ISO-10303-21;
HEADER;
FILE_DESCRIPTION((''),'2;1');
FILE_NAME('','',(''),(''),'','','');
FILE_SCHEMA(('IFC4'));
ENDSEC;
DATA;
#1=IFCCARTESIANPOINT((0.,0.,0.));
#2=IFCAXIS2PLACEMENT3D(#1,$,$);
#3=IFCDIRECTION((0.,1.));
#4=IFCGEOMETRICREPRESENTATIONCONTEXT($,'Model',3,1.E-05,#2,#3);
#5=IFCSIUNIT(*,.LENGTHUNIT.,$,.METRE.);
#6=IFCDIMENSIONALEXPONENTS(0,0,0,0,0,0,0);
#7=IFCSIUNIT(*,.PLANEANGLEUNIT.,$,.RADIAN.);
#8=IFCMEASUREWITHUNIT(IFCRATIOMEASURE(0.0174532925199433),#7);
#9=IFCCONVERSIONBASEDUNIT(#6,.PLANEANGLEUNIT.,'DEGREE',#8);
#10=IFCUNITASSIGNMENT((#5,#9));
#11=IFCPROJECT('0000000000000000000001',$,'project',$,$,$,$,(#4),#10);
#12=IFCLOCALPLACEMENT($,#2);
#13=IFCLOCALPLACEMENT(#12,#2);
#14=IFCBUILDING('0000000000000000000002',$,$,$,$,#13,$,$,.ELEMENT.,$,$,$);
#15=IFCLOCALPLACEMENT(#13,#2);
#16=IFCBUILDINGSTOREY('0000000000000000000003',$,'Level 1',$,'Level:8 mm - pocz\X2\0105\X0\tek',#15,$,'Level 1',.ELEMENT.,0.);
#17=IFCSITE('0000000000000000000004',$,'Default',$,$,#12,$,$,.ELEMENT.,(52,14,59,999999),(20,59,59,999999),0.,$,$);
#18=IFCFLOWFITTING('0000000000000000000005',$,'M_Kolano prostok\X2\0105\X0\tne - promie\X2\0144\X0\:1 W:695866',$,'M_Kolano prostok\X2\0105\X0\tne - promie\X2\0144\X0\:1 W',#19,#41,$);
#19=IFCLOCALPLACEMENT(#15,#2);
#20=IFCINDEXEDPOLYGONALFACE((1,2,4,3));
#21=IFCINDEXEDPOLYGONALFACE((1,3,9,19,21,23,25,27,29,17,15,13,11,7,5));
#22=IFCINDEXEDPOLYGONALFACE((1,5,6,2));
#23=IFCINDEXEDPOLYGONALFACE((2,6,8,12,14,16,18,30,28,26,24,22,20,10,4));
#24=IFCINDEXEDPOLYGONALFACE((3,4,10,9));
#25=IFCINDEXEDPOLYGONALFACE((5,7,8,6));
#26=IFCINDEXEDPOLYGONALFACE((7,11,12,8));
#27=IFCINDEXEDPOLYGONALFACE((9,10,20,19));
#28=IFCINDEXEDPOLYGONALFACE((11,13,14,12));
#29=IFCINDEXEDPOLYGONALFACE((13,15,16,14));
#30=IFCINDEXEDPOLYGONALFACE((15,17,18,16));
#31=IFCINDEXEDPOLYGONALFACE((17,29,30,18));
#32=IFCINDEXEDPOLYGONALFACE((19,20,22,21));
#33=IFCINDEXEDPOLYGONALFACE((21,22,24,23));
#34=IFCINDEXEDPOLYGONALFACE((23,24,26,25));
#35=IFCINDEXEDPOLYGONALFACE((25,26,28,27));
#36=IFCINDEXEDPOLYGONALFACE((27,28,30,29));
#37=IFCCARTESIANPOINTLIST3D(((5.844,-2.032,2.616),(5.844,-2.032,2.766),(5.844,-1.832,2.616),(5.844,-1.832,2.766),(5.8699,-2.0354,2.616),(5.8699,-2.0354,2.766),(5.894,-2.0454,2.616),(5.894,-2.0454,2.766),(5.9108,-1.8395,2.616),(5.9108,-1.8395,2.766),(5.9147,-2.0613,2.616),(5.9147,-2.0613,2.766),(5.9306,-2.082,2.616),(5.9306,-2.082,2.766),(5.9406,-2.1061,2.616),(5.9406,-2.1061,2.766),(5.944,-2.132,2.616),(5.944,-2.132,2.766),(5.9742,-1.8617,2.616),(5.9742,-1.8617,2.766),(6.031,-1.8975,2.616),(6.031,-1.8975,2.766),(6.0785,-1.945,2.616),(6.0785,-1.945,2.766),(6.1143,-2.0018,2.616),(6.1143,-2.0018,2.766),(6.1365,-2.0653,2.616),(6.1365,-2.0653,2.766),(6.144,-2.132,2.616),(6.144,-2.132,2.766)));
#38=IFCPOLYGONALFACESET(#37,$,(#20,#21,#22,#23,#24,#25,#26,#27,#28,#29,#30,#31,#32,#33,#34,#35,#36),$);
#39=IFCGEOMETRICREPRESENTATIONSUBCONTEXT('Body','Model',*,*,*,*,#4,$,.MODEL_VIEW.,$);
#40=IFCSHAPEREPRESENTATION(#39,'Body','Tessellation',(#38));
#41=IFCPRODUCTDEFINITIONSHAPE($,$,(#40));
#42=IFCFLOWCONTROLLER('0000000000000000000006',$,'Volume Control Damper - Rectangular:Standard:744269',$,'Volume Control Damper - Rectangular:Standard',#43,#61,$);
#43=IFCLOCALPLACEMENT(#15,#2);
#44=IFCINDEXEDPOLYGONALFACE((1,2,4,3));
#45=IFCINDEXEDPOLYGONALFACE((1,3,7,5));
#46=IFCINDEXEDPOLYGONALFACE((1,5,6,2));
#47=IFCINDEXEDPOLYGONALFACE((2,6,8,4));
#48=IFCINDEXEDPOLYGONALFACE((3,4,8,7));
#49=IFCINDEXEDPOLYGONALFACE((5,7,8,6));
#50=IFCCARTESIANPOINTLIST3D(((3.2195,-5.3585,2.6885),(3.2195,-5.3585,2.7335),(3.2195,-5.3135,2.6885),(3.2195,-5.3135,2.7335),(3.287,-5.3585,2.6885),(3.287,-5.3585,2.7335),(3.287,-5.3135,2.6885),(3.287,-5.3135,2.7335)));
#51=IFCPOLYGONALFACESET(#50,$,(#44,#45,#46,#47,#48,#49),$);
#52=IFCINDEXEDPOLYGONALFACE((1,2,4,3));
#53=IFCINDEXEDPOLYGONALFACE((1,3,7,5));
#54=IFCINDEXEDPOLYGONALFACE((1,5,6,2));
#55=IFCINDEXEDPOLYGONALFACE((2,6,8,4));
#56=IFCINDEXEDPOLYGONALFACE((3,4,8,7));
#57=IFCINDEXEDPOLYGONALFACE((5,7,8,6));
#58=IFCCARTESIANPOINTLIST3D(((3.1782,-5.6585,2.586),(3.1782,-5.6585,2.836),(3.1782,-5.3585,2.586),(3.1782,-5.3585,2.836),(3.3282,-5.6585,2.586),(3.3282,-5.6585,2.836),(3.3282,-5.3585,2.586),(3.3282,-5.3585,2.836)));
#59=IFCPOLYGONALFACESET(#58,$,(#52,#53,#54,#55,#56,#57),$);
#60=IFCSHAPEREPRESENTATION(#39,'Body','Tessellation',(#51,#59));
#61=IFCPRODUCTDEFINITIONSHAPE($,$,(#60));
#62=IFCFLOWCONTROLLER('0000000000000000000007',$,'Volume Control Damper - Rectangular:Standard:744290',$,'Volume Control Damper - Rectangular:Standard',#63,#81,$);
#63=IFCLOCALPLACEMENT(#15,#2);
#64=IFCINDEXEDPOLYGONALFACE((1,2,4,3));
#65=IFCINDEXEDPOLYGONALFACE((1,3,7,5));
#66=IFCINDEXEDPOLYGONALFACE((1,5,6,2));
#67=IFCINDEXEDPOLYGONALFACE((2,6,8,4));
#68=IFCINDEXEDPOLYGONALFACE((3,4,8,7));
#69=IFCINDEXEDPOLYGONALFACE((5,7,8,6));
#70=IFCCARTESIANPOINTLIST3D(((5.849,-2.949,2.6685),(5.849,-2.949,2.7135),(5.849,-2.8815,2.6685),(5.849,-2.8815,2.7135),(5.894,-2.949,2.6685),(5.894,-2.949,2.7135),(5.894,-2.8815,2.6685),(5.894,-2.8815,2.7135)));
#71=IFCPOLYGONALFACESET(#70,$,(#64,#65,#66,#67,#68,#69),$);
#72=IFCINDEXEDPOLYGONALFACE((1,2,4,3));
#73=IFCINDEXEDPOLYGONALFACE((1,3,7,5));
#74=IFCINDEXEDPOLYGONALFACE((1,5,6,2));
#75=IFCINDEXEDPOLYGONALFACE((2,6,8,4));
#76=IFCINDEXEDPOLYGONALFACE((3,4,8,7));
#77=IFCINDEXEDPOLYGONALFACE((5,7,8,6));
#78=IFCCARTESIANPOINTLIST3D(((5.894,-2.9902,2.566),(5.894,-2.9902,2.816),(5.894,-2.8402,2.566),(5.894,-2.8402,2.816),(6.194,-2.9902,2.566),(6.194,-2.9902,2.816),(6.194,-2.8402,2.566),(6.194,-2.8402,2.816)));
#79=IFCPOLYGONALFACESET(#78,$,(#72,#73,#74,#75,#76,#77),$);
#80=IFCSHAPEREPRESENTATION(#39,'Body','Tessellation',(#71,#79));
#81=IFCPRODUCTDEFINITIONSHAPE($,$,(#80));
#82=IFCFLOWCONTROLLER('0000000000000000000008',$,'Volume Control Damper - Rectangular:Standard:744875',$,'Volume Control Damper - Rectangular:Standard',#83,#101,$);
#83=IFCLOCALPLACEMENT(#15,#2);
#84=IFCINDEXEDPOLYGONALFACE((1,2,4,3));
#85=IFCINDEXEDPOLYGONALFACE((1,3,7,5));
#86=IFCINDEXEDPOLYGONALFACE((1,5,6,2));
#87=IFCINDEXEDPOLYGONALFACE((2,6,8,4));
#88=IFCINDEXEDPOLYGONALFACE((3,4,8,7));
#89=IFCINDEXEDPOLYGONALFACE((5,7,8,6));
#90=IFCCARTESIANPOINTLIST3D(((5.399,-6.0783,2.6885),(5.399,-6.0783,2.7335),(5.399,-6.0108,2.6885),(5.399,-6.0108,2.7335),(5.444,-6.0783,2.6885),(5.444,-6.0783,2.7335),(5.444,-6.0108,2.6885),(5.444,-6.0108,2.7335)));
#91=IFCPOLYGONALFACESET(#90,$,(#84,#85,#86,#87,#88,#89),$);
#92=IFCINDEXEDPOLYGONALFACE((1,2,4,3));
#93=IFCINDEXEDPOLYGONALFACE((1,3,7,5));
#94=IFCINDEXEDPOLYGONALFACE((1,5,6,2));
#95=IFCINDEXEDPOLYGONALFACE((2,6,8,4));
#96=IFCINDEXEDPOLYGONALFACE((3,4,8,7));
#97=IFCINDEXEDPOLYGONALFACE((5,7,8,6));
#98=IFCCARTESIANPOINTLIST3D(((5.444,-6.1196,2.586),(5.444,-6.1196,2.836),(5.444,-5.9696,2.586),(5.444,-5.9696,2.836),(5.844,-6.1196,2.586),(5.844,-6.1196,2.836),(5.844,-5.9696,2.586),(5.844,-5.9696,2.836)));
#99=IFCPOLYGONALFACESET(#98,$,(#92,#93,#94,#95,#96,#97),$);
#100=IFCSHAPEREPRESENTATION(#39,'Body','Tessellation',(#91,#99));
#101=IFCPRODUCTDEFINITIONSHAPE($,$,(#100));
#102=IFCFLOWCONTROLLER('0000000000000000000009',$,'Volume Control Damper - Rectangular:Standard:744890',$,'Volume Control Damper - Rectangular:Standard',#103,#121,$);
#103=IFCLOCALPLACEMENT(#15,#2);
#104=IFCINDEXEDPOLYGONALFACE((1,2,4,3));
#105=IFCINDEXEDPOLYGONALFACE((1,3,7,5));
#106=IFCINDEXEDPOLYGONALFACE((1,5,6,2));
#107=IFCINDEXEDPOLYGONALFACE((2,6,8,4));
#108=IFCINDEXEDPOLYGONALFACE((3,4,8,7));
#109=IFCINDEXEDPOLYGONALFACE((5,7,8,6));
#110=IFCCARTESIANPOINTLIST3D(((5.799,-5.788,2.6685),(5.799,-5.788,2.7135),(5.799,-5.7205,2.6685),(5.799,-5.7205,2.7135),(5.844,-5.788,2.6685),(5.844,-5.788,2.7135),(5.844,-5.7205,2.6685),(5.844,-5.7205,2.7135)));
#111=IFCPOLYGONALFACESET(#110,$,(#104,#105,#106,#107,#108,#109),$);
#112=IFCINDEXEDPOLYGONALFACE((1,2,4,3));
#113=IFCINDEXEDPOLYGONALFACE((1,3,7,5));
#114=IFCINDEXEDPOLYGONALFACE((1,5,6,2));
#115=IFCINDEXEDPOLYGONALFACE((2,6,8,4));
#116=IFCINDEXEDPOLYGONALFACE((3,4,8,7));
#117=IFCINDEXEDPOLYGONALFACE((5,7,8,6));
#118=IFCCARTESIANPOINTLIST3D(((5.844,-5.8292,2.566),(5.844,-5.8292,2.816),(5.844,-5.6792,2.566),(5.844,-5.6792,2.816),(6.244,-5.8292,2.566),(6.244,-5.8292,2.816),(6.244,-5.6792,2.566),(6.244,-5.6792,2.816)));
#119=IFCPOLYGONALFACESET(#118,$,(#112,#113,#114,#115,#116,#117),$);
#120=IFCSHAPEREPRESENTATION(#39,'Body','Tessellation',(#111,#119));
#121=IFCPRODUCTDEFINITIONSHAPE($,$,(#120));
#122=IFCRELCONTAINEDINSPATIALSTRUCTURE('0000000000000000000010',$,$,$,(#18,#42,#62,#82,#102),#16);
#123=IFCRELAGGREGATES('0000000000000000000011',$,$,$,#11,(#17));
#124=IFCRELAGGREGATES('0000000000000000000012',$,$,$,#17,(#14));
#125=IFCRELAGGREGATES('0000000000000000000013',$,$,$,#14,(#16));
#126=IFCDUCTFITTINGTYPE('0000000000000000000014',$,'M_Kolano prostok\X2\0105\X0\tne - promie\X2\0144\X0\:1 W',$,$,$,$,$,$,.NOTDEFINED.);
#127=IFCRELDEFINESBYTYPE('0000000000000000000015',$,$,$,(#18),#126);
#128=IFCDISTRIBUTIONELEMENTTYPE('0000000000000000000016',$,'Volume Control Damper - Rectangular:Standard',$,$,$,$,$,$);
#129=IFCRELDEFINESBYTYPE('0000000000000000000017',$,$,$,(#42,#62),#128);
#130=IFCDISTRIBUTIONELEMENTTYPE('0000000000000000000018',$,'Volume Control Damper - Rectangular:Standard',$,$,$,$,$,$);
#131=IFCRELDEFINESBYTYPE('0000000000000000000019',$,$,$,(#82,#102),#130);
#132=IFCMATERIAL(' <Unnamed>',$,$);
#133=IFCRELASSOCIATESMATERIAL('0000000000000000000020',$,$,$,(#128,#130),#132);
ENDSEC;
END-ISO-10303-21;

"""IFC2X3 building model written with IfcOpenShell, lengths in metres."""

from ifc_helpers import new_model, entity, si_unit, converted_unit, direction, frame, frame_2d, origin, origin_2d_with_axis, place, context, subcontext, project, spatial, polyline, circle_curve, parameter, trimmed, segment, composite_curve, rectangle, outline, extrude, source, transform, mapped, material, type_object, type_shapes, element, save


model = new_model("IFC2X3")

# Units and contexts
model_context = context("Model", 3, precision=1e-05, world=origin(), true_north=direction((0.0, 1.0)))
body_context = subcontext(model_context, "Body", "Model", "MODEL_VIEW")
ifc_project = project(units=[si_unit("LENGTHUNIT", "METRE"), converted_unit("PLANEANGLEUNIT", "DEGREE", entity("IfcRatioMeasure", 0.0174532925199433), si_unit("PLANEANGLEUNIT", "RADIAN"), dimensions=[0, 0, 0, 0, 0, 0, 0])], contexts=[model_context])

# Site, building, storey
site_placement = place(None, origin())
site = spatial("IfcSite", under=ifc_project, at=site_placement, Name="Default", CompositionType="ELEMENT", RefLatitude=(52, 14, 59, 999999), RefLongitude=(20, 59, 59, 999999), RefElevation=0.0)
building_placement = place(site_placement, origin())
building = spatial("IfcBuilding", under=site, at=building_placement, CompositionType="ELEMENT")
storey_placement = place(building_placement, origin())
storey = spatial("IfcBuildingStorey", under=building, at=storey_placement, Name="Level 1", ObjectType="Level:8 mm - początek", LongName="Level 1", CompositionType="ELEMENT", Elevation=0.0)

# Flow fitting
duct_fitting_type_1 = type_object("IfcDuctFittingType", Name="M_Kolano prostokątne - promień:1 W", PredefinedType="NOTDEFINED")
shared_shape_1 = source(origin(), body_context, "Body", "SweptSolid", [
    extrude(outline(composite_curve([segment(polyline([(-0.2, -0.1), (0.0, -0.1)]), True, "CONTINUOUS"), segment(trimmed(circle_curve(frame_2d((0.1, -0.1), x_axis=(0.0, 1.0)), 0.1), [parameter(0.0)], [parameter(90.0)], True, "PARAMETER"), False, "CONTINUOUS"), segment(polyline([(0.1, 0.0), (0.1, 0.2)]), True, "CONTINUOUS"), segment(trimmed(circle_curve(frame_2d((0.1, -0.1), x_axis=(0.0, 1.0)), 0.3), [parameter(0.0)], [parameter(90.0)], True, "PARAMETER"), True, "CONTINUOUS")], self_intersect=False)), frame((-0.1, 0.1, -0.075), z_axis=(0.0, 0.0, 1.0), x_axis=(-1.0, 0.0, 0.0)), (0.0, 0.0, 1.0), 0.15),
])
type_shapes(duct_fitting_type_1, [shared_shape_1])
flow_fitting_1_placement = place(storey_placement, frame((6.044, -1.932, 2.691), z_axis=(0.0, 0.0, 1.0), x_axis=(0.0, 1.0, 0.0)))
element("IfcFlowFitting", 1, at=flow_fitting_1_placement, inside=storey, type_object=duct_fitting_type_1, Name="M_Kolano prostokątne - promień:1 W:695866", ObjectType="M_Kolano prostokątne - promień:1 W", context=body_context, shape_type="MappedRepresentation", body=[
    mapped(shared_shape_1, transform((0.0, 0.0, 0.0), scale=1.0)),
])

# Flow controllers
ifc_material = material(Name=" <Unnamed>")
distribution_element_type_1 = type_object("IfcDistributionElementType", Name="Volume Control Damper - Rectangular:Standard", material=ifc_material)
shared_shape_2 = source(origin(), body_context, "Body", "SweptSolid", [
    extrude(rectangle(XDim=0.0675, YDim=0.045, at=frame_2d((0.0, 0.0), x_axis=(1.0, 0.0))), frame((0.0, 0.1725, -0.0225), z_axis=(0.0, 0.0, 1.0), x_axis=(-1.0, 0.0, 0.0)), (0.0, 0.0, 1.0), 0.045),
    extrude(rectangle(XDim=0.15, YDim=0.3, at=origin_2d_with_axis()), frame((0.0, 0.0, -0.125), z_axis=(0.0, 0.0, 1.0), x_axis=(-1.0, 0.0, 0.0)), (0.0, 0.0, 1.0), 0.25),
])
type_shapes(distribution_element_type_1, [shared_shape_2])
for number, where, z_axis, x_axis, name in (
    (2, (3.2532, -5.5085, 2.711), (0.0, 0.0, -1.0), (-1.0, 0.0, 0.0), "Volume Control Damper - Rectangular:Standard:744269"),
    (3, (6.044, -2.9152, 2.691), (0.0, 0.0, -1.0), (0.0, -1.0, 0.0), "Volume Control Damper - Rectangular:Standard:744290"),
):
    element("IfcFlowController", number, at=place(storey_placement, frame(where, z_axis=z_axis, x_axis=x_axis)), inside=storey, type_object=distribution_element_type_1, Name=name, ObjectType="Volume Control Damper - Rectangular:Standard", context=body_context, shape_type="MappedRepresentation", body=[
        mapped(shared_shape_2, transform((0.0, 0.0, 0.0), scale=1.0)),
    ])
distribution_element_type_2 = type_object("IfcDistributionElementType", Name="Volume Control Damper - Rectangular:Standard", material=ifc_material)
shared_shape_3 = source(origin(), body_context, "Body", "SweptSolid", [
    extrude(rectangle(XDim=0.0675, YDim=0.045, at=origin_2d_with_axis()), frame((0.0, 0.2225, -0.0225), z_axis=(0.0, 0.0, 1.0), x_axis=(-1.0, 0.0, 0.0)), (0.0, 0.0, 1.0), 0.045),
    extrude(rectangle(XDim=0.15, YDim=0.4, at=origin_2d_with_axis()), frame((0.0, 0.0, -0.125), z_axis=(0.0, 0.0, 1.0), x_axis=(-1.0, 0.0, 0.0)), (0.0, 0.0, 1.0), 0.25),
])
type_shapes(distribution_element_type_2, [shared_shape_3])
for number, where, z_axis, x_axis, name in (
    (4, (5.644, -6.0446, 2.711), (0.0, 0.0, -1.0), (0.0, -1.0, 0.0), "Volume Control Damper - Rectangular:Standard:744875"),
    (5, (6.044, -5.7542, 2.691), (0.0, 0.0, -1.0), (0.0, -1.0, 0.0), "Volume Control Damper - Rectangular:Standard:744890"),
):
    element("IfcFlowController", number, at=place(storey_placement, frame(where, z_axis=z_axis, x_axis=x_axis)), inside=storey, type_object=distribution_element_type_2, Name=name, ObjectType="Volume Control Damper - Rectangular:Standard", context=body_context, shape_type="MappedRepresentation", body=[
        mapped(shared_shape_3, transform((0.0, 0.0, 0.0), scale=1.0)),
    ])

save(model, "model.ifc")
